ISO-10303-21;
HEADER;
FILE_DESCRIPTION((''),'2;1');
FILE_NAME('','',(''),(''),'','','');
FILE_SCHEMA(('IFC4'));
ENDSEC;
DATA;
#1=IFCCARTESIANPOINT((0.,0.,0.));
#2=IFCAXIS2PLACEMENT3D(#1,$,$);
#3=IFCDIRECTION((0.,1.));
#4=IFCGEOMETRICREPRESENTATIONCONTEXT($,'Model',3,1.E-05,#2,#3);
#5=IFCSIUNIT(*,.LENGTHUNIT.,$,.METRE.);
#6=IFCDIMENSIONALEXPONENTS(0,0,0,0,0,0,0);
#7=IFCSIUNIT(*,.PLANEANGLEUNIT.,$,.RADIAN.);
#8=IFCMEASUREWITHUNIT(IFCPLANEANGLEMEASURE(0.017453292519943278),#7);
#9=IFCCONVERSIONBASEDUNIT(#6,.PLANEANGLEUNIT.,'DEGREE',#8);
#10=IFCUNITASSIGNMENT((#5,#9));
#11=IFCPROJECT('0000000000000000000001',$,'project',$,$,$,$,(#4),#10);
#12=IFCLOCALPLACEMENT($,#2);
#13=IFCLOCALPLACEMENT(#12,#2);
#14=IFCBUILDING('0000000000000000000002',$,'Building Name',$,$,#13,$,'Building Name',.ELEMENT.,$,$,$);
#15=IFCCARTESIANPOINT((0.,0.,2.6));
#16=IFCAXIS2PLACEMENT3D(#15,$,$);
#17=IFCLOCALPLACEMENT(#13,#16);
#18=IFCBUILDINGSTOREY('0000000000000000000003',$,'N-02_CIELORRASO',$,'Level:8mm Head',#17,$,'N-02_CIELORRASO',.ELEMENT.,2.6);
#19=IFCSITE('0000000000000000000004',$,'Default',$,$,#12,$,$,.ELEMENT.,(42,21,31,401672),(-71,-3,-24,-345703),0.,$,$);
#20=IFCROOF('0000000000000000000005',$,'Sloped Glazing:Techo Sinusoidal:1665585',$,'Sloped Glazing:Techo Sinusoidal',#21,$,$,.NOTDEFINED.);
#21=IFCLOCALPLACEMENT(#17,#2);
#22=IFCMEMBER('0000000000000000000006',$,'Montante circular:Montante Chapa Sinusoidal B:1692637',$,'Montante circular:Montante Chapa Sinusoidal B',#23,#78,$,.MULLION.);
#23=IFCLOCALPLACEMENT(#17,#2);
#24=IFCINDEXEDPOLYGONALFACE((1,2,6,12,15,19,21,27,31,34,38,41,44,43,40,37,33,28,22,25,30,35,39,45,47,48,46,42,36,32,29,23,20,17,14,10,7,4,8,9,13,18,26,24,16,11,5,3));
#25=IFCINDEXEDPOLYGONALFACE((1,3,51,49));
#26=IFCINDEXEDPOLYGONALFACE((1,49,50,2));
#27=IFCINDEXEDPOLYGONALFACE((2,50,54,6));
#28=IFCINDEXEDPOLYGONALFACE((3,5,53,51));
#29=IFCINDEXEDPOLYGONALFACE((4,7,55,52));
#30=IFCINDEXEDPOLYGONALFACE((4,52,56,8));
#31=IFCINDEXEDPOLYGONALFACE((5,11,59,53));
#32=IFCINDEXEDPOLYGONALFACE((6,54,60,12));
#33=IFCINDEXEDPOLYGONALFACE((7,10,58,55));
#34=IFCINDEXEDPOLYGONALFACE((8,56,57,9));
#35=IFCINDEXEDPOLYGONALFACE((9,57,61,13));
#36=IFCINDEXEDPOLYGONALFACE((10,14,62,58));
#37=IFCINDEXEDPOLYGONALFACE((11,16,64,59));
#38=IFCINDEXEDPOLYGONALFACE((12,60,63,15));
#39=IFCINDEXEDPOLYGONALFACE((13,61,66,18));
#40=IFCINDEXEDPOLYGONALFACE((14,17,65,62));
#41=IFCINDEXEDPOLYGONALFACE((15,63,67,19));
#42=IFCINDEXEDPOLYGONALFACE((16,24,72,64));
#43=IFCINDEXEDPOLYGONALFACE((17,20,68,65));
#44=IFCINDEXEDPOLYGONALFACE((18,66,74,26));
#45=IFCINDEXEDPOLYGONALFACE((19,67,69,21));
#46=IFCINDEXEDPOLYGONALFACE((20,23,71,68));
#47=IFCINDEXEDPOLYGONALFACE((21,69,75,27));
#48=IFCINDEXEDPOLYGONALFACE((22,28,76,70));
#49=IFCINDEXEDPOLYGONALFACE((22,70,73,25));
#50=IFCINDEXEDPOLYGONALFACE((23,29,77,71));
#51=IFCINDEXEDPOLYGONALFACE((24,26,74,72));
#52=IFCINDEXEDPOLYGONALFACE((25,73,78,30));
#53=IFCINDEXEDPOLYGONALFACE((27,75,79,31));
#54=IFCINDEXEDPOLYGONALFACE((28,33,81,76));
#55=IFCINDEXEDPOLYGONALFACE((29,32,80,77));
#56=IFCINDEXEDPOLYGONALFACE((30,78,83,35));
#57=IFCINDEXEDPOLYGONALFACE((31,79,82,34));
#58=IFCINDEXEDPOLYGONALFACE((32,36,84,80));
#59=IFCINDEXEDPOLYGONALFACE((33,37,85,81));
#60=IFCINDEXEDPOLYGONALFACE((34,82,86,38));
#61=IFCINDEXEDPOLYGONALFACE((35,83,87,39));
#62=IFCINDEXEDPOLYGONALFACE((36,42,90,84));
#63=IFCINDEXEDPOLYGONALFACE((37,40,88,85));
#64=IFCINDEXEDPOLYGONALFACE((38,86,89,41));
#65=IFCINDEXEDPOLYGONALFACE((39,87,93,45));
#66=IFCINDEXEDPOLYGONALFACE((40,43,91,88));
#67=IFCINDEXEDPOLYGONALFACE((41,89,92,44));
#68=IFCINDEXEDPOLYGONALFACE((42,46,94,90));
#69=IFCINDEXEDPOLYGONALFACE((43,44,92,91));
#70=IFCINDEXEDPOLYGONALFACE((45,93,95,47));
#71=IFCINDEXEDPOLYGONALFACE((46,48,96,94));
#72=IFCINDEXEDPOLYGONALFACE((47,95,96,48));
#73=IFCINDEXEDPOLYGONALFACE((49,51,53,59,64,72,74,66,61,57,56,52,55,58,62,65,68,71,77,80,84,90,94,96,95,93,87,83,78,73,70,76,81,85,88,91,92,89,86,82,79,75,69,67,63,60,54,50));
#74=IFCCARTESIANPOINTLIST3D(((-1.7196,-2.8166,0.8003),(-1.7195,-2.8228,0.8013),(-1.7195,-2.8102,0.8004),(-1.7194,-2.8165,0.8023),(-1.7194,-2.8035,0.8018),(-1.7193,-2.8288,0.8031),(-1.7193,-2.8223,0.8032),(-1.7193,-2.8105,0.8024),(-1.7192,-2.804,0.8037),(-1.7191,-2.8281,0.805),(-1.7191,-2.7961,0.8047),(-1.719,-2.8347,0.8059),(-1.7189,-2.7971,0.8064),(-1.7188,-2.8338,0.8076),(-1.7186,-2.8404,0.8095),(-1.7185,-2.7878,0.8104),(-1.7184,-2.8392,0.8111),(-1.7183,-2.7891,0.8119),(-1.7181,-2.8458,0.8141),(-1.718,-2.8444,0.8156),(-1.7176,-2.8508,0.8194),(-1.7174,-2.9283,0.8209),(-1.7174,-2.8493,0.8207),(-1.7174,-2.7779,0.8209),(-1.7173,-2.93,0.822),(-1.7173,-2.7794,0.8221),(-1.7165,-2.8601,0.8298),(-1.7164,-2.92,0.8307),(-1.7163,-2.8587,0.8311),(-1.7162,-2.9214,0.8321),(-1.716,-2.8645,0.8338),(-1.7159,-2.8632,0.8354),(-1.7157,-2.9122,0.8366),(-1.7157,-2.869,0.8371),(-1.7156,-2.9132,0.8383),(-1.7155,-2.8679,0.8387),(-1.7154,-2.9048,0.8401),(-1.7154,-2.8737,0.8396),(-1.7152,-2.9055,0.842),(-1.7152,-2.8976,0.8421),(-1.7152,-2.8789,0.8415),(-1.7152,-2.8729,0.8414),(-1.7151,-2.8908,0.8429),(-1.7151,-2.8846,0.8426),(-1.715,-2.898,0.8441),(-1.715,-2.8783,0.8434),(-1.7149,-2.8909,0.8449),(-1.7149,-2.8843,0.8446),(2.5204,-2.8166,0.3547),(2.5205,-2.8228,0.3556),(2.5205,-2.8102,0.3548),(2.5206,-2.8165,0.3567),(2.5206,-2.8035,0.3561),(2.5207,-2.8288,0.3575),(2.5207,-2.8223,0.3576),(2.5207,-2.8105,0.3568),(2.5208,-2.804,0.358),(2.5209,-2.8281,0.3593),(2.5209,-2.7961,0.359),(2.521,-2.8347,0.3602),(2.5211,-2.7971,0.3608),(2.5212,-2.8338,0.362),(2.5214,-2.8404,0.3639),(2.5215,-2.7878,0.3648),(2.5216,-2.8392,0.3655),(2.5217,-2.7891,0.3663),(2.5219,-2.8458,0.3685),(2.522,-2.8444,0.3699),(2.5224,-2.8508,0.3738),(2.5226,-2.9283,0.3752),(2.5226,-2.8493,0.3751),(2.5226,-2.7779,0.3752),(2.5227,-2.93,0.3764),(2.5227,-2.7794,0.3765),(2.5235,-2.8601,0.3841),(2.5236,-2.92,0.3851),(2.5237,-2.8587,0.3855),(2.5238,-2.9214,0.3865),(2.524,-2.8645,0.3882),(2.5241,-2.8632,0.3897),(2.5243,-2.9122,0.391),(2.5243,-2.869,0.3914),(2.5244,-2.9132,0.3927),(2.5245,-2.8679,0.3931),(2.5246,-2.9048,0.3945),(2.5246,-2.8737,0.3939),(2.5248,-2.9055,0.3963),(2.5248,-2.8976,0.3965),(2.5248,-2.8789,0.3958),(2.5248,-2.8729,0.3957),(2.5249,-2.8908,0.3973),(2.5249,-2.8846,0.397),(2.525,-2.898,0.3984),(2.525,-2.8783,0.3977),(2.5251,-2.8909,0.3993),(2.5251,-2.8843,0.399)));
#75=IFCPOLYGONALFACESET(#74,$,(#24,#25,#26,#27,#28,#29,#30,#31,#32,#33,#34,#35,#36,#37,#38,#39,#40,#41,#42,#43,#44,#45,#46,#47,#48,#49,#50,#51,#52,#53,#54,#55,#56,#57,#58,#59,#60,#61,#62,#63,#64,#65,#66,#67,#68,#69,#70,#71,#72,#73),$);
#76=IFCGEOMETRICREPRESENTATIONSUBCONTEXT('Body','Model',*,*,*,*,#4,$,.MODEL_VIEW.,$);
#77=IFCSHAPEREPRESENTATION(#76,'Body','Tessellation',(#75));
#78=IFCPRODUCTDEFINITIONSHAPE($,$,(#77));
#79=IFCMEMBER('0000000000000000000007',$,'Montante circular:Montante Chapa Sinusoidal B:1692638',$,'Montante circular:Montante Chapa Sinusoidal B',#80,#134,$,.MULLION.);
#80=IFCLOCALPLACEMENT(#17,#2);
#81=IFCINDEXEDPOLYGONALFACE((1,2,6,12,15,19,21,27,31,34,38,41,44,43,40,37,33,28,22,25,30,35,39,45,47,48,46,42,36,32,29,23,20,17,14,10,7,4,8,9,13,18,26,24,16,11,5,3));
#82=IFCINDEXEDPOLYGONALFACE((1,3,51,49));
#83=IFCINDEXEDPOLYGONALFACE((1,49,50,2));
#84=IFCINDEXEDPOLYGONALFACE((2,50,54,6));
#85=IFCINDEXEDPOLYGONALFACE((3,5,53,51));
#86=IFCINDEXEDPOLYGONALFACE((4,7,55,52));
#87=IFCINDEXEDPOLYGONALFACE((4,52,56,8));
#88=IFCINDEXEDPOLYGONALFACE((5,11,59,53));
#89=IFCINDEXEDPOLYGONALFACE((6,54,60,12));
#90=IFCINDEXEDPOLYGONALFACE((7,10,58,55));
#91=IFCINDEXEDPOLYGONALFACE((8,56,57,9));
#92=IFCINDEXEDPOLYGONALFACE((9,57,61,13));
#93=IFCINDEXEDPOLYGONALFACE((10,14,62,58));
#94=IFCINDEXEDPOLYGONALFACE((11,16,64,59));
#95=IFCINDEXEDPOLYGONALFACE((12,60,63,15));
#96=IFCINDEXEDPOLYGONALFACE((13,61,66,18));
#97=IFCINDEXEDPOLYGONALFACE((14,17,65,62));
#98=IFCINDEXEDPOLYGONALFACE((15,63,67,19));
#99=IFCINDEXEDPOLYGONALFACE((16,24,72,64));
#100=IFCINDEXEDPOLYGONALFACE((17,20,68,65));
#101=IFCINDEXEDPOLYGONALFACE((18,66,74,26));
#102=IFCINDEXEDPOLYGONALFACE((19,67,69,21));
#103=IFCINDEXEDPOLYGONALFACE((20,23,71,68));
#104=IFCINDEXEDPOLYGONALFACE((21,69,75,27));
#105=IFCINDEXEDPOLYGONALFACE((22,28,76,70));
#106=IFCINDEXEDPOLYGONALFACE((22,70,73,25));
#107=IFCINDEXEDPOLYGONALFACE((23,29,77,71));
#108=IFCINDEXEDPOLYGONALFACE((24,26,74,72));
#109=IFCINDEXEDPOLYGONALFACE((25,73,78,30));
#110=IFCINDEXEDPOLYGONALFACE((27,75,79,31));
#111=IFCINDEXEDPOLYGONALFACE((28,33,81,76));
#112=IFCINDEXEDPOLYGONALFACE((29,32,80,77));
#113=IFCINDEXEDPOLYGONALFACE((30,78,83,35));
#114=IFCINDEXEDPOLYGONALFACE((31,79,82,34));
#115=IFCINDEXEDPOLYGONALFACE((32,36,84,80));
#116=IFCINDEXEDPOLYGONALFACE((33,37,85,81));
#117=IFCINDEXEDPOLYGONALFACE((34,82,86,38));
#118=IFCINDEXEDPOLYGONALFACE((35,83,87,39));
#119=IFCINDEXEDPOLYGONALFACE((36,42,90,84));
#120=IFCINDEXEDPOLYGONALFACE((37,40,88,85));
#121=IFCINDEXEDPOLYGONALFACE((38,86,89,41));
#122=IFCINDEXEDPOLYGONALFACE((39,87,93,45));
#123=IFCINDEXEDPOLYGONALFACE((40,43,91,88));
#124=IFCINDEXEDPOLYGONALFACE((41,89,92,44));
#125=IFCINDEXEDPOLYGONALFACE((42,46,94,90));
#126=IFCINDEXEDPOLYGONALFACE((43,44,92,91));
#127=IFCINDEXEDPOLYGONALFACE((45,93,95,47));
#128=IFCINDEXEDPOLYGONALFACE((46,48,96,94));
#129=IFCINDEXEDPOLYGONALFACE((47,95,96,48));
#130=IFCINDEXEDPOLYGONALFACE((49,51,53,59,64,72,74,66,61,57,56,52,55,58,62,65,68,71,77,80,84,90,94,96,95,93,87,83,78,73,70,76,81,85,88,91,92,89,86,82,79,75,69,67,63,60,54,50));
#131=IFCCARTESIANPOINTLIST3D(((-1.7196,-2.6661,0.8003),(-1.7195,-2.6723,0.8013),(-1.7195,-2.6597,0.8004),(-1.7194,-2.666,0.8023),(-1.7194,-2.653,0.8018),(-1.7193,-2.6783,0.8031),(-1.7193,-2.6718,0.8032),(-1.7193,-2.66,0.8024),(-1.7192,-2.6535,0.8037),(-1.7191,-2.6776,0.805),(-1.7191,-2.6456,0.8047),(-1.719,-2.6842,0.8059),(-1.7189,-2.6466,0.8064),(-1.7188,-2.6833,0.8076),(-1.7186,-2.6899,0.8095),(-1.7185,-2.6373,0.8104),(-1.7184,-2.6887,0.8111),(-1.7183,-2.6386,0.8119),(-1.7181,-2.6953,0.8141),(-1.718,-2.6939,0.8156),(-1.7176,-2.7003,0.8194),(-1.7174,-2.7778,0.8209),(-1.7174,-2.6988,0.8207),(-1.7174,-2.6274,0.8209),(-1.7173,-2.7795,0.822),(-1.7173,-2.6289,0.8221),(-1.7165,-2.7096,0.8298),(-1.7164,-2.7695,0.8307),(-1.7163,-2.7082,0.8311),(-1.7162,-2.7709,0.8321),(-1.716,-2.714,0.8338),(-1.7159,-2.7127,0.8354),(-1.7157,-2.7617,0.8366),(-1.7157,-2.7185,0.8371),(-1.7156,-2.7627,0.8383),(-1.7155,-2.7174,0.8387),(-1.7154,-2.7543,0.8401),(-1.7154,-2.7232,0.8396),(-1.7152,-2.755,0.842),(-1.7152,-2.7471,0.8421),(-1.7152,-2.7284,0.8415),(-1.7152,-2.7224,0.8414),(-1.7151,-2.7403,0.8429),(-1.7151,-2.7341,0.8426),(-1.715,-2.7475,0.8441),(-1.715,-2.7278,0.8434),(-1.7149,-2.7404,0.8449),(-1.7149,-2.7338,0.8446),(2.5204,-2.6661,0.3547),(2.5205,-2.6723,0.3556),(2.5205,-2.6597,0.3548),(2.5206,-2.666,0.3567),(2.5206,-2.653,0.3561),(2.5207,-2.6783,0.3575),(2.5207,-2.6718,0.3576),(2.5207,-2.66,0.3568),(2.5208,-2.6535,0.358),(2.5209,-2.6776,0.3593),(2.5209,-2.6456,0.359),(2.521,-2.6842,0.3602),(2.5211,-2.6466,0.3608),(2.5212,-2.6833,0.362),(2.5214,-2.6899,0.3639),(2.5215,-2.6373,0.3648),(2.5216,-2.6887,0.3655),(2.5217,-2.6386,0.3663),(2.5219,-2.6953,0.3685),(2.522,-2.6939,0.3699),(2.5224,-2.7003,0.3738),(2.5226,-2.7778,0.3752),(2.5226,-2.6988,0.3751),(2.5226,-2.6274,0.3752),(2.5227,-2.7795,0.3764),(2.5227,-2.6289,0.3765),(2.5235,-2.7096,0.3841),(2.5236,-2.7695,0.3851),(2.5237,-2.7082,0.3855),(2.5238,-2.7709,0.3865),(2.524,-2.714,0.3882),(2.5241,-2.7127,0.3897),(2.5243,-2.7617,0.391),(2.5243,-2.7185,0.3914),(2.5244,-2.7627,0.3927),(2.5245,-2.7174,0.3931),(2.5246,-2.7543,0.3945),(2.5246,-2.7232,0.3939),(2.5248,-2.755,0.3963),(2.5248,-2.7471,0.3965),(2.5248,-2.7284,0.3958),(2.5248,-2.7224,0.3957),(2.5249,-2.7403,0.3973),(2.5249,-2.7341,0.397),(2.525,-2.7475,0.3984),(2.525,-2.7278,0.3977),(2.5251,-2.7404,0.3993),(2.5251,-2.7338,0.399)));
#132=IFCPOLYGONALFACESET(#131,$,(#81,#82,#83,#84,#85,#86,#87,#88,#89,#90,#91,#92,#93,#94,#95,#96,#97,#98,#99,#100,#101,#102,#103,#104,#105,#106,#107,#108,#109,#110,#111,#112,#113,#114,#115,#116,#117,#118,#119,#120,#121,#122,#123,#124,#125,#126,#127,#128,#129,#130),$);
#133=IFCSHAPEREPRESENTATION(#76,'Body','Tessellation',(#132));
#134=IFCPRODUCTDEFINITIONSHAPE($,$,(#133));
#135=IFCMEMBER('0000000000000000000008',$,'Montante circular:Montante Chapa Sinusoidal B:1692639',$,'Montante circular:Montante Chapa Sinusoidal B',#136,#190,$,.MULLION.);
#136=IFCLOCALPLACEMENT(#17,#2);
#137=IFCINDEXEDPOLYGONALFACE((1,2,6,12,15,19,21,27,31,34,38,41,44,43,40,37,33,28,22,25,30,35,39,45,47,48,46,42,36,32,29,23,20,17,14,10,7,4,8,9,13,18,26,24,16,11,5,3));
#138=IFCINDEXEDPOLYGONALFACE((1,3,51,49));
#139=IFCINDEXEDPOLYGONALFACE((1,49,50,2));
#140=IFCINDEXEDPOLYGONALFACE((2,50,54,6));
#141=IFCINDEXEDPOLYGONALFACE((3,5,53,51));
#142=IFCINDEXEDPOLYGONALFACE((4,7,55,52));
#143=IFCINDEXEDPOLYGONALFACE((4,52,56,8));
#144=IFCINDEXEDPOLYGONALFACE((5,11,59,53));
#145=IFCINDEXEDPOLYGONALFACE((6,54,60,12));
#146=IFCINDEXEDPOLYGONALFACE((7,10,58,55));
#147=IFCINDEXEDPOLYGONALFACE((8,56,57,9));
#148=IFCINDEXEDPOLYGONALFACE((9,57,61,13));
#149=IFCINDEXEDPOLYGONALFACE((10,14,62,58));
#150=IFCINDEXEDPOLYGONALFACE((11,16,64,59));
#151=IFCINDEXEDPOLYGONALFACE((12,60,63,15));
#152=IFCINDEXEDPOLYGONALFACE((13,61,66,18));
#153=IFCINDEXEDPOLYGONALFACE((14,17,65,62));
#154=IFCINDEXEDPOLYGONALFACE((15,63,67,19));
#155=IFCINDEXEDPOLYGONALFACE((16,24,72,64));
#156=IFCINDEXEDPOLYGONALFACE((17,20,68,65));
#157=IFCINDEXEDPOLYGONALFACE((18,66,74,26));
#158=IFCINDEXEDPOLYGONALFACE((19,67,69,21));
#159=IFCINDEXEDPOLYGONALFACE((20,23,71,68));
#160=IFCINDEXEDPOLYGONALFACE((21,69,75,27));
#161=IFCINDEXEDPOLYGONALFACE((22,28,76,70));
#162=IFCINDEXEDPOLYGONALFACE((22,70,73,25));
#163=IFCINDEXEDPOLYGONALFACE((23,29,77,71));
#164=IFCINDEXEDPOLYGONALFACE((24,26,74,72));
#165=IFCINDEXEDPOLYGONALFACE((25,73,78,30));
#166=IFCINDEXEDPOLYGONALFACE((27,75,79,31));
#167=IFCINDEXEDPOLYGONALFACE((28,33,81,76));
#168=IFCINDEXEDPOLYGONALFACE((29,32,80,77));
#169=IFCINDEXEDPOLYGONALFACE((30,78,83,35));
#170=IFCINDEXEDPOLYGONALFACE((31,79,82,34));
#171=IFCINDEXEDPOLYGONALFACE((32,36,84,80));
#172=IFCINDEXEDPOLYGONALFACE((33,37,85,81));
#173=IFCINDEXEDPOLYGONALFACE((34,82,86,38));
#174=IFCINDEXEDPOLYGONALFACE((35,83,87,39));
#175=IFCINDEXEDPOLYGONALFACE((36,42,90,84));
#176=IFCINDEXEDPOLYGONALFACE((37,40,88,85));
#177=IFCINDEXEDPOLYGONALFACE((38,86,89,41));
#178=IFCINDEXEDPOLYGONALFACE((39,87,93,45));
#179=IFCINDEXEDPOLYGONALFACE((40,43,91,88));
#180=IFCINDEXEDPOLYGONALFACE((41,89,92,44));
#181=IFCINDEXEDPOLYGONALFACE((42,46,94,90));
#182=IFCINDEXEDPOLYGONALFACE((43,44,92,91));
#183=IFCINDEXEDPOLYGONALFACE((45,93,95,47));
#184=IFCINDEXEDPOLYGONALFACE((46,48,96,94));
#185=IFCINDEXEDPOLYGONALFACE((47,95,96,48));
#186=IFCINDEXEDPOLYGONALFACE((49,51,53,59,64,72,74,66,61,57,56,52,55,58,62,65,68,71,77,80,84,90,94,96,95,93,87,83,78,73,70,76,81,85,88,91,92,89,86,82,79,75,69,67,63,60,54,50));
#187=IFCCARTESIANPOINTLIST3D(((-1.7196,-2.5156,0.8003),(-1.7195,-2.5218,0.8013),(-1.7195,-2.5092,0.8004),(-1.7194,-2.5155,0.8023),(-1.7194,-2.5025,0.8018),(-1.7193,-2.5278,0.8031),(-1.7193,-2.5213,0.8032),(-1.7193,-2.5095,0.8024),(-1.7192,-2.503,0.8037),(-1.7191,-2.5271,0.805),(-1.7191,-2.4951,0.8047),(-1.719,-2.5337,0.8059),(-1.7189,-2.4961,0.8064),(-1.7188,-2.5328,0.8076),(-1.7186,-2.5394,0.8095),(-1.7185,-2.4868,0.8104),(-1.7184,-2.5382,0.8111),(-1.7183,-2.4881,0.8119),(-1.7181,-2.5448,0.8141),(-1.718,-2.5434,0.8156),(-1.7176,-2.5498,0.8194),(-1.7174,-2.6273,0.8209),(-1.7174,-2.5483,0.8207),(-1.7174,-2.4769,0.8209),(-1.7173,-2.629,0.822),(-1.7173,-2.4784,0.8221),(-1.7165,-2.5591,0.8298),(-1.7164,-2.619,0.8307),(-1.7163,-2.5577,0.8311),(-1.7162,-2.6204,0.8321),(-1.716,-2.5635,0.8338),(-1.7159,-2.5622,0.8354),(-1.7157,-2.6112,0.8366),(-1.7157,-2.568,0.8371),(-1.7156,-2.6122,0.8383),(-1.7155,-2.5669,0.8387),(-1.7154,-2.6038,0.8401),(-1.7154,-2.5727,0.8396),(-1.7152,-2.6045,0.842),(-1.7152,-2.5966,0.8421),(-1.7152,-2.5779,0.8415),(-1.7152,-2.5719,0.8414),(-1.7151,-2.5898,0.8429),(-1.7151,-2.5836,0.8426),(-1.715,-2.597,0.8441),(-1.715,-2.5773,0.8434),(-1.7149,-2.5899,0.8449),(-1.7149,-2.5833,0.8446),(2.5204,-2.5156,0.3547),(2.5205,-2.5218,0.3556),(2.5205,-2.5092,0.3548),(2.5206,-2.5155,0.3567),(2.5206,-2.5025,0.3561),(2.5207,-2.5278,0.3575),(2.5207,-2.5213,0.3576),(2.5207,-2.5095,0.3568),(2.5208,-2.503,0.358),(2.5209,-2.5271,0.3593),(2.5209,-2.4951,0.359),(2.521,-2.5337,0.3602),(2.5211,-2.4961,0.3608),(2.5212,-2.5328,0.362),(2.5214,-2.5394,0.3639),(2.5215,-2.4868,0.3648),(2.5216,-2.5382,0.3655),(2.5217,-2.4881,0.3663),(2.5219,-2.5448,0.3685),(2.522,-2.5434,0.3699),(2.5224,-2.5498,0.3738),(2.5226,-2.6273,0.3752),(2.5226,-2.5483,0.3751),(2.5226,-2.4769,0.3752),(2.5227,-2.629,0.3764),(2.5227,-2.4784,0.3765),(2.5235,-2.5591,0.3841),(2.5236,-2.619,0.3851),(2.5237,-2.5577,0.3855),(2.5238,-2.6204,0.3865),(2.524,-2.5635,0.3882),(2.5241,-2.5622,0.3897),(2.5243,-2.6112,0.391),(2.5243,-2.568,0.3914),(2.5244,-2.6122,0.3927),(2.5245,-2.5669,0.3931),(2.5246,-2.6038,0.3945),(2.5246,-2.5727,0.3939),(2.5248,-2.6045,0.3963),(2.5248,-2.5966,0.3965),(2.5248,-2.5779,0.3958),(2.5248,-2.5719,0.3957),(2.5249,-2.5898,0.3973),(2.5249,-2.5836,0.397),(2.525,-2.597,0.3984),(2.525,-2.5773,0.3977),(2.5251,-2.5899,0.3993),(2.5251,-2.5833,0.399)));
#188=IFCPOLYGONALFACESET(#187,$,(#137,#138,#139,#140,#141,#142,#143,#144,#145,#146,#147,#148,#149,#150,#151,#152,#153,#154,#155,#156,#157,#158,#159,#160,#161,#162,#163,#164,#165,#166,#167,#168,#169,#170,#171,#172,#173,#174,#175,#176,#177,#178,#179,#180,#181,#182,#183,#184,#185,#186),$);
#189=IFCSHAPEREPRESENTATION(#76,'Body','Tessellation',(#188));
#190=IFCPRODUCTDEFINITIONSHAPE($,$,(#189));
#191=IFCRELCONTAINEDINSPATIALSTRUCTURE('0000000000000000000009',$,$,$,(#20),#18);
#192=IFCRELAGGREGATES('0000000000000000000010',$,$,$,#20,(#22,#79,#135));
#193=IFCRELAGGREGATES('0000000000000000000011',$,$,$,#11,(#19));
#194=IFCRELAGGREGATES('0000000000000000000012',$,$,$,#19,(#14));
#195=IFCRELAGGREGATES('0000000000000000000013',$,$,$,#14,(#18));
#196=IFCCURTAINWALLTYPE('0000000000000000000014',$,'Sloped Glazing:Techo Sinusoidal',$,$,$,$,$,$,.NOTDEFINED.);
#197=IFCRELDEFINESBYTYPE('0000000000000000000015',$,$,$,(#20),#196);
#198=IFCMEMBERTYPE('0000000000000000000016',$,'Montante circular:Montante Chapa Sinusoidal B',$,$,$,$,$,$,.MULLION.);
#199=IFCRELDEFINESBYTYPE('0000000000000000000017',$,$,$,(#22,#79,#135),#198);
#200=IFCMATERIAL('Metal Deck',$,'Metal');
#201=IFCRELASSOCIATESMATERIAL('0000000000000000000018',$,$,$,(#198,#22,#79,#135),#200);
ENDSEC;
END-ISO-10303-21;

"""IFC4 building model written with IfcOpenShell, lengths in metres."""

from ifc_helpers import new_model, entity, si_unit, converted_unit, direction, frame, origin, place, context, subcontext, project, spatial, indexed_curve, outline, extrude, source, transform, mapped, material, type_object, type_shapes, element, aggregate, save


model = new_model("IFC4")

# Units and contexts
model_context = context("Model", 3, precision=1e-05, world=origin(), true_north=direction((0.0, 1.0)))
body_context = subcontext(model_context, "Body", "Model", "MODEL_VIEW")
ifc_project = project(units=[si_unit("LENGTHUNIT", "METRE"), converted_unit("PLANEANGLEUNIT", "DEGREE", entity("IfcPlaneAngleMeasure", 0.017453292519943278), si_unit("PLANEANGLEUNIT", "RADIAN"), dimensions=[0, 0, 0, 0, 0, 0, 0])], contexts=[model_context])

# Site, building, storey
site_placement = place(None, origin())
site = spatial("IfcSite", under=ifc_project, at=site_placement, Name="Default", CompositionType="ELEMENT", RefLatitude=(42, 21, 31, 401672), RefLongitude=(-71, -3, -24, -345703), RefElevation=0.0)
building_placement = place(site_placement, origin())
building = spatial("IfcBuilding", under=site, at=building_placement, Name="Building Name", LongName="Building Name", CompositionType="ELEMENT")
storey_placement = place(building_placement, frame((0.0, 0.0, 2.6)))
storey = spatial("IfcBuildingStorey", under=building, at=storey_placement, Name="N-02_CIELORRASO", ObjectType="Level:8mm Head", LongName="N-02_CIELORRASO", CompositionType="ELEMENT", Elevation=2.6)

# Roof, members
curtain_wall_type = type_object("IfcCurtainWallType", Name="Sloped Glazing:Techo Sinusoidal", PredefinedType="NOTDEFINED")
roof_placement = place(storey_placement, frame((0.0, 0.0, -2.6)))
roof = element("IfcRoof", 1, at=roof_placement, inside=storey, type_object=curtain_wall_type, Name="Sloped Glazing:Techo Sinusoidal:1665585", ObjectType="Sloped Glazing:Techo Sinusoidal", PredefinedType="NOTDEFINED")
ifc_material_1 = material(Name="Metal Deck", Category="Metal")
member_type = type_object("IfcMemberType", Name="Montante circular:Montante Chapa Sinusoidal B", PredefinedType="MULLION", material=ifc_material_1)
shared_shape_1 = source(origin(), body_context, "Body", "SweptSolid", [
    extrude(outline(indexed_curve([(0.0595, -0.0443), (0.0615, -0.0443), (0.0603, -0.031), (0.0572, -0.0213), (0.053, -0.0138), (0.0481, -0.0078), (0.0427, -0.003), (0.0372, 0.0005), (0.0315, 0.0029), (0.0259, 0.0044), (0.0203, 0.0051), (0.0146, 0.005), (0.0084, 0.0041), (-0.0053, 0.0009), (-0.0123, -0.0005), (-0.0191, -0.0012), (-0.0256, -0.001), (-0.0317, 0.0001), (-0.0375, 0.0019), (-0.0428, 0.0046), (-0.0477, 0.0081), (-0.0522, 0.0128), (-0.0563, 0.0191), (-0.0597, 0.0282), (-0.0617, 0.0421), (-0.0637, 0.042), (-0.0616, 0.0277), (-0.0581, 0.0182), (-0.0537, 0.0116), (-0.049, 0.0066), (-0.0438, 0.0028), (-0.0382, 0.0001), (-0.0322, -0.0019), (-0.0258, -0.003), (-0.019, -0.0032), (-0.012, -0.0025), (-0.0048, -0.0011), (0.0088, 0.0021), (0.0147, 0.003), (0.0202, 0.0031), (0.0255, 0.0024), (0.0309, 0.001), (0.0362, -0.0013), (0.0415, -0.0046), (0.0466, -0.0092), (0.0513, -0.0149), (0.0554, -0.0221), (0.0584, -0.0314), (0.0595, -0.0443)], self_intersect=False)), frame((-0.007, 0.0228, -4.2634), z_axis=(0.0, 0.0, 1.0), x_axis=(-0.819152, -0.573576, 0.0)), (0.0, 0.0, 1.0), 4.2634),
])
type_shapes(member_type, [shared_shape_1])
member_1_placement = place(roof_placement, frame((-1.7148, -2.8471, 3.4456), z_axis=(-0.994522, 0.0, 0.104528), x_axis=(0.0, 1.0, 0.0)))
member_1 = element("IfcMember", 2, at=member_1_placement, type_object=member_type, material=ifc_material_1, Name="Montante circular:Montante Chapa Sinusoidal B:1692637", ObjectType="Montante circular:Montante Chapa Sinusoidal B", PredefinedType="MULLION", context=body_context, shape_type="MappedRepresentation", body=[
    mapped(shared_shape_1, transform((0.0, 0.0, 0.0), scale=1.0)),
])
member_2_placement = place(roof_placement, frame((-1.7148, -2.6966, 3.4456), z_axis=(-0.994522, 0.0, 0.104528), x_axis=(0.0, 1.0, 0.0)))
member_2 = element("IfcMember", 3, at=member_2_placement, type_object=member_type, material=ifc_material_1, Name="Montante circular:Montante Chapa Sinusoidal B:1692638", ObjectType="Montante circular:Montante Chapa Sinusoidal B", PredefinedType="MULLION", context=body_context, shape_type="MappedRepresentation", body=[
    mapped(shared_shape_1, transform((0.0, 0.0, 0.0), scale=1.0)),
])
member_3_placement = place(roof_placement, frame((-1.7148, -2.5461, 3.4456), z_axis=(-0.994522, 0.0, 0.104528), x_axis=(0.0, 1.0, 0.0)))
member_3 = element("IfcMember", 4, at=member_3_placement, type_object=member_type, material=ifc_material_1, Name="Montante circular:Montante Chapa Sinusoidal B:1692639", ObjectType="Montante circular:Montante Chapa Sinusoidal B", PredefinedType="MULLION", context=body_context, shape_type="MappedRepresentation", body=[
    mapped(shared_shape_1, transform((0.0, 0.0, 0.0), scale=1.0)),
])
aggregate(roof, [member_1, member_2, member_3])

save(model, "model.ifc")
